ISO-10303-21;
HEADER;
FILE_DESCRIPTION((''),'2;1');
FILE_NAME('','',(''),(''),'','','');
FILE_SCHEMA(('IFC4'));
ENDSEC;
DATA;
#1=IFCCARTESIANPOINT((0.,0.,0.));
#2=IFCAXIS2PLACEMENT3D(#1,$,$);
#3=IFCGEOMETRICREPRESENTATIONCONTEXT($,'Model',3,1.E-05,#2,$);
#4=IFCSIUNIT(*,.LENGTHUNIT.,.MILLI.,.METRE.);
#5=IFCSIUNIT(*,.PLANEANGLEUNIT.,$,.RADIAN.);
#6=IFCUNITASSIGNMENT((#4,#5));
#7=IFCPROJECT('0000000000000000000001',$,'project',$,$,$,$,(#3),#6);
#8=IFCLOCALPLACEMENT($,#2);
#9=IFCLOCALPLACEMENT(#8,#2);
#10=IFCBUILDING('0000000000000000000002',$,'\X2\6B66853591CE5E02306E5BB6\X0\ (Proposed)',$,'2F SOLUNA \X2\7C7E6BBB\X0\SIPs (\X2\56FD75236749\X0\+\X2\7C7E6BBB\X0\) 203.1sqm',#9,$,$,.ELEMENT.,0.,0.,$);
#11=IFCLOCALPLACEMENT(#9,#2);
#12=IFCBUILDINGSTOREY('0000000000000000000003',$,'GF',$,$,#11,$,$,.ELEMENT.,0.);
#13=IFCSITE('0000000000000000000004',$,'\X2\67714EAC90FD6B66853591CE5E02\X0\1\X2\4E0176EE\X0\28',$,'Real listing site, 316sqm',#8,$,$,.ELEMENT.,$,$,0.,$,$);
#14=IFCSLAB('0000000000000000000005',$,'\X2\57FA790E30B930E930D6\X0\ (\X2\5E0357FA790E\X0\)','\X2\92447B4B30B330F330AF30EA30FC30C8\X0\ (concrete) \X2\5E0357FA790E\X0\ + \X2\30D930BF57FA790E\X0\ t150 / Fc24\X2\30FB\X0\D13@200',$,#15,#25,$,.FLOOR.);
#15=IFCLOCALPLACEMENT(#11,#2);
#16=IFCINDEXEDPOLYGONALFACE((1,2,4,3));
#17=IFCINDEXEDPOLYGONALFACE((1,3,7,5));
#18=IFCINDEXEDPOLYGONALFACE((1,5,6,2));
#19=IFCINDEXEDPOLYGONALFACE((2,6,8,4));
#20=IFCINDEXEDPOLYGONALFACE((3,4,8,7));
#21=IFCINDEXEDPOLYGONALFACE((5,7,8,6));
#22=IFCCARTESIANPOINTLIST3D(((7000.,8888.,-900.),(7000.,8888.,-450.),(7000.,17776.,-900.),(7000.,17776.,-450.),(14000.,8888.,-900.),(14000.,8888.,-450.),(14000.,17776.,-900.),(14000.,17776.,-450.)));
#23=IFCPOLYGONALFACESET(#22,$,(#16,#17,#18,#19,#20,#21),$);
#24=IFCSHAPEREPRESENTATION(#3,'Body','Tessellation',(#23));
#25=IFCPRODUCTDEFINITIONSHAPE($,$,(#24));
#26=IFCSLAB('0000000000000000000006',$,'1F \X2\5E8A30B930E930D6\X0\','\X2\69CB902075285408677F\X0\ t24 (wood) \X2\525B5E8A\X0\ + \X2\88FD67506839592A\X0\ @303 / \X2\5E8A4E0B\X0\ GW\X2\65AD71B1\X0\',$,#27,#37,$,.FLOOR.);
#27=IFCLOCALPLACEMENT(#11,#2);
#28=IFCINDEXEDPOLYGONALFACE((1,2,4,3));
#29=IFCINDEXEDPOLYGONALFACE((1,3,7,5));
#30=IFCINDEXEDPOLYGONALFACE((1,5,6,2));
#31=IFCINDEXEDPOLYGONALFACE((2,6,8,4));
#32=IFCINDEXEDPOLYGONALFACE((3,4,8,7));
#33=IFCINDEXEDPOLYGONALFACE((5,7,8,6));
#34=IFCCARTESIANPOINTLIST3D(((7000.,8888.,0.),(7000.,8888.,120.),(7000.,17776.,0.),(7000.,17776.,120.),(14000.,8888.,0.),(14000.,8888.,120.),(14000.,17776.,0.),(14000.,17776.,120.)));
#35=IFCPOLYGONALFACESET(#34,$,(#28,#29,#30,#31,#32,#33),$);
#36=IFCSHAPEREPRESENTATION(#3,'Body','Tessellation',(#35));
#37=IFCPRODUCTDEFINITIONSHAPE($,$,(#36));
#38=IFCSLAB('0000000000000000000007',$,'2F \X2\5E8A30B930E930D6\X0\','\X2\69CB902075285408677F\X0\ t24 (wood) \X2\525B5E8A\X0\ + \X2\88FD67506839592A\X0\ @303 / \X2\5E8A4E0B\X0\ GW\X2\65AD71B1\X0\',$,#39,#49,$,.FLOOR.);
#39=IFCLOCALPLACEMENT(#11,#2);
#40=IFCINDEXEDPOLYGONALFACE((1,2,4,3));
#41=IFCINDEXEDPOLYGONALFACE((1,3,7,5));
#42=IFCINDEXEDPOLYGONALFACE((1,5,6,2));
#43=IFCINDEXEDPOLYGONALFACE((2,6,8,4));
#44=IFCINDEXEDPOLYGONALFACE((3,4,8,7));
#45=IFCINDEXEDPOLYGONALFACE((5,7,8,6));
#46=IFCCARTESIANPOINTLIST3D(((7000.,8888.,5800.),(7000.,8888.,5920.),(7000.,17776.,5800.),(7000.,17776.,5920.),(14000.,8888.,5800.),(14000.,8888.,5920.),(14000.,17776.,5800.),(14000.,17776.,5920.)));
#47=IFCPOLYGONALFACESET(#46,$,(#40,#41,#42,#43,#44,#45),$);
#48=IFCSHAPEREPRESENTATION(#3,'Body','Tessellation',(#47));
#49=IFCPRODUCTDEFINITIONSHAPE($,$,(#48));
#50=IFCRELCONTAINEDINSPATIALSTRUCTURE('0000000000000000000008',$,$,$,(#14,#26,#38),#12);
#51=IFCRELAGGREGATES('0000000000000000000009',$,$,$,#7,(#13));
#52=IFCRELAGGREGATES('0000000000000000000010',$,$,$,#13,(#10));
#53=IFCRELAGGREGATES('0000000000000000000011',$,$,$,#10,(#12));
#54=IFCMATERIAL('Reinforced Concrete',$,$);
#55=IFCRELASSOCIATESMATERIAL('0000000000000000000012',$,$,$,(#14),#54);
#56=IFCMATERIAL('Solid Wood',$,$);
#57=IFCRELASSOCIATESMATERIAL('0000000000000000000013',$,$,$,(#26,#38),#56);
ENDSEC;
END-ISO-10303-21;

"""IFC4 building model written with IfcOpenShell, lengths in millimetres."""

from ifc_helpers import new_model, si_unit, frame, frame_2d, origin, place, context, project, spatial, rectangle, extrude, material, element, save


model = new_model("IFC4")

# Units and contexts
model_context = context("Model", 3, precision=1e-05, world=origin())
ifc_project = project(units=[si_unit("LENGTHUNIT", "METRE", prefix="MILLI"), si_unit("PLANEANGLEUNIT", "RADIAN")], contexts=[model_context])

# Site, building, storey
site_placement = place(None, origin())
site = spatial("IfcSite", under=ifc_project, at=site_placement, Name="東京都武蔵野市1丁目28", ObjectType="Real listing site, 316sqm", CompositionType="ELEMENT", RefElevation=0.0)
building_placement = place(site_placement, origin())
building = spatial("IfcBuilding", under=site, at=building_placement, Name="武蔵野市の家 (Proposed)", ObjectType="2F SOLUNA 籾殻SIPs (国産杉+籾殻) 203.1sqm", CompositionType="ELEMENT", ElevationOfRefHeight=0.0, ElevationOfTerrain=0.0)
storey_placement = place(building_placement, origin())
storey = spatial("IfcBuildingStorey", under=building, at=storey_placement, Name="GF", CompositionType="ELEMENT", Elevation=0.0)

# Slabs
ifc_material_1 = material(Name="Reinforced Concrete")
slab_1_placement = place(storey_placement, frame((3500.0, 4444.0, -450.0)))
element("IfcSlab", 1, at=slab_1_placement, inside=storey, material=ifc_material_1, Name="基礎スラブ (布基礎)", Description="鉄筋コンクリート (concrete) 布基礎 + ベタ基礎 t150 / Fc24・D13@200", PredefinedType="FLOOR", context=model_context, shape_type="SweptSolid", body=[
    extrude(rectangle(XDim=7000.0, YDim=8888.0, at=frame_2d((3500.0, 4444.0))), frame((3500.0, 4444.0, -450.0)), (0.0, 0.0, 1.0), 450.0),
])
ifc_material_2 = material(Name="Solid Wood")
slab_2_placement = place(storey_placement, frame((3500.0, 4444.0, 0.0)))
element("IfcSlab", 2, at=slab_2_placement, inside=storey, material=ifc_material_2, Name="1F 床スラブ", Description="構造用合板 t24 (wood) 剛床 + 製材根太 @303 / 床下 GW断熱", PredefinedType="FLOOR", context=model_context, shape_type="SweptSolid", body=[
    extrude(rectangle(XDim=7000.0, YDim=8888.0, at=frame_2d((3500.0, 4444.0))), frame((3500.0, 4444.0, 0.0)), (0.0, 0.0, 1.0), 120.0),
])
slab_3_placement = place(storey_placement, frame((3500.0, 4444.0, 2900.0)))
element("IfcSlab", 3, at=slab_3_placement, inside=storey, material=ifc_material_2, Name="2F 床スラブ", Description="構造用合板 t24 (wood) 剛床 + 製材根太 @303 / 床下 GW断熱", PredefinedType="FLOOR", context=model_context, shape_type="SweptSolid", body=[
    extrude(rectangle(XDim=7000.0, YDim=8888.0, at=frame_2d((3500.0, 4444.0))), frame((3500.0, 4444.0, 2900.0)), (0.0, 0.0, 1.0), 120.0),
])

save(model, "model.ifc")
